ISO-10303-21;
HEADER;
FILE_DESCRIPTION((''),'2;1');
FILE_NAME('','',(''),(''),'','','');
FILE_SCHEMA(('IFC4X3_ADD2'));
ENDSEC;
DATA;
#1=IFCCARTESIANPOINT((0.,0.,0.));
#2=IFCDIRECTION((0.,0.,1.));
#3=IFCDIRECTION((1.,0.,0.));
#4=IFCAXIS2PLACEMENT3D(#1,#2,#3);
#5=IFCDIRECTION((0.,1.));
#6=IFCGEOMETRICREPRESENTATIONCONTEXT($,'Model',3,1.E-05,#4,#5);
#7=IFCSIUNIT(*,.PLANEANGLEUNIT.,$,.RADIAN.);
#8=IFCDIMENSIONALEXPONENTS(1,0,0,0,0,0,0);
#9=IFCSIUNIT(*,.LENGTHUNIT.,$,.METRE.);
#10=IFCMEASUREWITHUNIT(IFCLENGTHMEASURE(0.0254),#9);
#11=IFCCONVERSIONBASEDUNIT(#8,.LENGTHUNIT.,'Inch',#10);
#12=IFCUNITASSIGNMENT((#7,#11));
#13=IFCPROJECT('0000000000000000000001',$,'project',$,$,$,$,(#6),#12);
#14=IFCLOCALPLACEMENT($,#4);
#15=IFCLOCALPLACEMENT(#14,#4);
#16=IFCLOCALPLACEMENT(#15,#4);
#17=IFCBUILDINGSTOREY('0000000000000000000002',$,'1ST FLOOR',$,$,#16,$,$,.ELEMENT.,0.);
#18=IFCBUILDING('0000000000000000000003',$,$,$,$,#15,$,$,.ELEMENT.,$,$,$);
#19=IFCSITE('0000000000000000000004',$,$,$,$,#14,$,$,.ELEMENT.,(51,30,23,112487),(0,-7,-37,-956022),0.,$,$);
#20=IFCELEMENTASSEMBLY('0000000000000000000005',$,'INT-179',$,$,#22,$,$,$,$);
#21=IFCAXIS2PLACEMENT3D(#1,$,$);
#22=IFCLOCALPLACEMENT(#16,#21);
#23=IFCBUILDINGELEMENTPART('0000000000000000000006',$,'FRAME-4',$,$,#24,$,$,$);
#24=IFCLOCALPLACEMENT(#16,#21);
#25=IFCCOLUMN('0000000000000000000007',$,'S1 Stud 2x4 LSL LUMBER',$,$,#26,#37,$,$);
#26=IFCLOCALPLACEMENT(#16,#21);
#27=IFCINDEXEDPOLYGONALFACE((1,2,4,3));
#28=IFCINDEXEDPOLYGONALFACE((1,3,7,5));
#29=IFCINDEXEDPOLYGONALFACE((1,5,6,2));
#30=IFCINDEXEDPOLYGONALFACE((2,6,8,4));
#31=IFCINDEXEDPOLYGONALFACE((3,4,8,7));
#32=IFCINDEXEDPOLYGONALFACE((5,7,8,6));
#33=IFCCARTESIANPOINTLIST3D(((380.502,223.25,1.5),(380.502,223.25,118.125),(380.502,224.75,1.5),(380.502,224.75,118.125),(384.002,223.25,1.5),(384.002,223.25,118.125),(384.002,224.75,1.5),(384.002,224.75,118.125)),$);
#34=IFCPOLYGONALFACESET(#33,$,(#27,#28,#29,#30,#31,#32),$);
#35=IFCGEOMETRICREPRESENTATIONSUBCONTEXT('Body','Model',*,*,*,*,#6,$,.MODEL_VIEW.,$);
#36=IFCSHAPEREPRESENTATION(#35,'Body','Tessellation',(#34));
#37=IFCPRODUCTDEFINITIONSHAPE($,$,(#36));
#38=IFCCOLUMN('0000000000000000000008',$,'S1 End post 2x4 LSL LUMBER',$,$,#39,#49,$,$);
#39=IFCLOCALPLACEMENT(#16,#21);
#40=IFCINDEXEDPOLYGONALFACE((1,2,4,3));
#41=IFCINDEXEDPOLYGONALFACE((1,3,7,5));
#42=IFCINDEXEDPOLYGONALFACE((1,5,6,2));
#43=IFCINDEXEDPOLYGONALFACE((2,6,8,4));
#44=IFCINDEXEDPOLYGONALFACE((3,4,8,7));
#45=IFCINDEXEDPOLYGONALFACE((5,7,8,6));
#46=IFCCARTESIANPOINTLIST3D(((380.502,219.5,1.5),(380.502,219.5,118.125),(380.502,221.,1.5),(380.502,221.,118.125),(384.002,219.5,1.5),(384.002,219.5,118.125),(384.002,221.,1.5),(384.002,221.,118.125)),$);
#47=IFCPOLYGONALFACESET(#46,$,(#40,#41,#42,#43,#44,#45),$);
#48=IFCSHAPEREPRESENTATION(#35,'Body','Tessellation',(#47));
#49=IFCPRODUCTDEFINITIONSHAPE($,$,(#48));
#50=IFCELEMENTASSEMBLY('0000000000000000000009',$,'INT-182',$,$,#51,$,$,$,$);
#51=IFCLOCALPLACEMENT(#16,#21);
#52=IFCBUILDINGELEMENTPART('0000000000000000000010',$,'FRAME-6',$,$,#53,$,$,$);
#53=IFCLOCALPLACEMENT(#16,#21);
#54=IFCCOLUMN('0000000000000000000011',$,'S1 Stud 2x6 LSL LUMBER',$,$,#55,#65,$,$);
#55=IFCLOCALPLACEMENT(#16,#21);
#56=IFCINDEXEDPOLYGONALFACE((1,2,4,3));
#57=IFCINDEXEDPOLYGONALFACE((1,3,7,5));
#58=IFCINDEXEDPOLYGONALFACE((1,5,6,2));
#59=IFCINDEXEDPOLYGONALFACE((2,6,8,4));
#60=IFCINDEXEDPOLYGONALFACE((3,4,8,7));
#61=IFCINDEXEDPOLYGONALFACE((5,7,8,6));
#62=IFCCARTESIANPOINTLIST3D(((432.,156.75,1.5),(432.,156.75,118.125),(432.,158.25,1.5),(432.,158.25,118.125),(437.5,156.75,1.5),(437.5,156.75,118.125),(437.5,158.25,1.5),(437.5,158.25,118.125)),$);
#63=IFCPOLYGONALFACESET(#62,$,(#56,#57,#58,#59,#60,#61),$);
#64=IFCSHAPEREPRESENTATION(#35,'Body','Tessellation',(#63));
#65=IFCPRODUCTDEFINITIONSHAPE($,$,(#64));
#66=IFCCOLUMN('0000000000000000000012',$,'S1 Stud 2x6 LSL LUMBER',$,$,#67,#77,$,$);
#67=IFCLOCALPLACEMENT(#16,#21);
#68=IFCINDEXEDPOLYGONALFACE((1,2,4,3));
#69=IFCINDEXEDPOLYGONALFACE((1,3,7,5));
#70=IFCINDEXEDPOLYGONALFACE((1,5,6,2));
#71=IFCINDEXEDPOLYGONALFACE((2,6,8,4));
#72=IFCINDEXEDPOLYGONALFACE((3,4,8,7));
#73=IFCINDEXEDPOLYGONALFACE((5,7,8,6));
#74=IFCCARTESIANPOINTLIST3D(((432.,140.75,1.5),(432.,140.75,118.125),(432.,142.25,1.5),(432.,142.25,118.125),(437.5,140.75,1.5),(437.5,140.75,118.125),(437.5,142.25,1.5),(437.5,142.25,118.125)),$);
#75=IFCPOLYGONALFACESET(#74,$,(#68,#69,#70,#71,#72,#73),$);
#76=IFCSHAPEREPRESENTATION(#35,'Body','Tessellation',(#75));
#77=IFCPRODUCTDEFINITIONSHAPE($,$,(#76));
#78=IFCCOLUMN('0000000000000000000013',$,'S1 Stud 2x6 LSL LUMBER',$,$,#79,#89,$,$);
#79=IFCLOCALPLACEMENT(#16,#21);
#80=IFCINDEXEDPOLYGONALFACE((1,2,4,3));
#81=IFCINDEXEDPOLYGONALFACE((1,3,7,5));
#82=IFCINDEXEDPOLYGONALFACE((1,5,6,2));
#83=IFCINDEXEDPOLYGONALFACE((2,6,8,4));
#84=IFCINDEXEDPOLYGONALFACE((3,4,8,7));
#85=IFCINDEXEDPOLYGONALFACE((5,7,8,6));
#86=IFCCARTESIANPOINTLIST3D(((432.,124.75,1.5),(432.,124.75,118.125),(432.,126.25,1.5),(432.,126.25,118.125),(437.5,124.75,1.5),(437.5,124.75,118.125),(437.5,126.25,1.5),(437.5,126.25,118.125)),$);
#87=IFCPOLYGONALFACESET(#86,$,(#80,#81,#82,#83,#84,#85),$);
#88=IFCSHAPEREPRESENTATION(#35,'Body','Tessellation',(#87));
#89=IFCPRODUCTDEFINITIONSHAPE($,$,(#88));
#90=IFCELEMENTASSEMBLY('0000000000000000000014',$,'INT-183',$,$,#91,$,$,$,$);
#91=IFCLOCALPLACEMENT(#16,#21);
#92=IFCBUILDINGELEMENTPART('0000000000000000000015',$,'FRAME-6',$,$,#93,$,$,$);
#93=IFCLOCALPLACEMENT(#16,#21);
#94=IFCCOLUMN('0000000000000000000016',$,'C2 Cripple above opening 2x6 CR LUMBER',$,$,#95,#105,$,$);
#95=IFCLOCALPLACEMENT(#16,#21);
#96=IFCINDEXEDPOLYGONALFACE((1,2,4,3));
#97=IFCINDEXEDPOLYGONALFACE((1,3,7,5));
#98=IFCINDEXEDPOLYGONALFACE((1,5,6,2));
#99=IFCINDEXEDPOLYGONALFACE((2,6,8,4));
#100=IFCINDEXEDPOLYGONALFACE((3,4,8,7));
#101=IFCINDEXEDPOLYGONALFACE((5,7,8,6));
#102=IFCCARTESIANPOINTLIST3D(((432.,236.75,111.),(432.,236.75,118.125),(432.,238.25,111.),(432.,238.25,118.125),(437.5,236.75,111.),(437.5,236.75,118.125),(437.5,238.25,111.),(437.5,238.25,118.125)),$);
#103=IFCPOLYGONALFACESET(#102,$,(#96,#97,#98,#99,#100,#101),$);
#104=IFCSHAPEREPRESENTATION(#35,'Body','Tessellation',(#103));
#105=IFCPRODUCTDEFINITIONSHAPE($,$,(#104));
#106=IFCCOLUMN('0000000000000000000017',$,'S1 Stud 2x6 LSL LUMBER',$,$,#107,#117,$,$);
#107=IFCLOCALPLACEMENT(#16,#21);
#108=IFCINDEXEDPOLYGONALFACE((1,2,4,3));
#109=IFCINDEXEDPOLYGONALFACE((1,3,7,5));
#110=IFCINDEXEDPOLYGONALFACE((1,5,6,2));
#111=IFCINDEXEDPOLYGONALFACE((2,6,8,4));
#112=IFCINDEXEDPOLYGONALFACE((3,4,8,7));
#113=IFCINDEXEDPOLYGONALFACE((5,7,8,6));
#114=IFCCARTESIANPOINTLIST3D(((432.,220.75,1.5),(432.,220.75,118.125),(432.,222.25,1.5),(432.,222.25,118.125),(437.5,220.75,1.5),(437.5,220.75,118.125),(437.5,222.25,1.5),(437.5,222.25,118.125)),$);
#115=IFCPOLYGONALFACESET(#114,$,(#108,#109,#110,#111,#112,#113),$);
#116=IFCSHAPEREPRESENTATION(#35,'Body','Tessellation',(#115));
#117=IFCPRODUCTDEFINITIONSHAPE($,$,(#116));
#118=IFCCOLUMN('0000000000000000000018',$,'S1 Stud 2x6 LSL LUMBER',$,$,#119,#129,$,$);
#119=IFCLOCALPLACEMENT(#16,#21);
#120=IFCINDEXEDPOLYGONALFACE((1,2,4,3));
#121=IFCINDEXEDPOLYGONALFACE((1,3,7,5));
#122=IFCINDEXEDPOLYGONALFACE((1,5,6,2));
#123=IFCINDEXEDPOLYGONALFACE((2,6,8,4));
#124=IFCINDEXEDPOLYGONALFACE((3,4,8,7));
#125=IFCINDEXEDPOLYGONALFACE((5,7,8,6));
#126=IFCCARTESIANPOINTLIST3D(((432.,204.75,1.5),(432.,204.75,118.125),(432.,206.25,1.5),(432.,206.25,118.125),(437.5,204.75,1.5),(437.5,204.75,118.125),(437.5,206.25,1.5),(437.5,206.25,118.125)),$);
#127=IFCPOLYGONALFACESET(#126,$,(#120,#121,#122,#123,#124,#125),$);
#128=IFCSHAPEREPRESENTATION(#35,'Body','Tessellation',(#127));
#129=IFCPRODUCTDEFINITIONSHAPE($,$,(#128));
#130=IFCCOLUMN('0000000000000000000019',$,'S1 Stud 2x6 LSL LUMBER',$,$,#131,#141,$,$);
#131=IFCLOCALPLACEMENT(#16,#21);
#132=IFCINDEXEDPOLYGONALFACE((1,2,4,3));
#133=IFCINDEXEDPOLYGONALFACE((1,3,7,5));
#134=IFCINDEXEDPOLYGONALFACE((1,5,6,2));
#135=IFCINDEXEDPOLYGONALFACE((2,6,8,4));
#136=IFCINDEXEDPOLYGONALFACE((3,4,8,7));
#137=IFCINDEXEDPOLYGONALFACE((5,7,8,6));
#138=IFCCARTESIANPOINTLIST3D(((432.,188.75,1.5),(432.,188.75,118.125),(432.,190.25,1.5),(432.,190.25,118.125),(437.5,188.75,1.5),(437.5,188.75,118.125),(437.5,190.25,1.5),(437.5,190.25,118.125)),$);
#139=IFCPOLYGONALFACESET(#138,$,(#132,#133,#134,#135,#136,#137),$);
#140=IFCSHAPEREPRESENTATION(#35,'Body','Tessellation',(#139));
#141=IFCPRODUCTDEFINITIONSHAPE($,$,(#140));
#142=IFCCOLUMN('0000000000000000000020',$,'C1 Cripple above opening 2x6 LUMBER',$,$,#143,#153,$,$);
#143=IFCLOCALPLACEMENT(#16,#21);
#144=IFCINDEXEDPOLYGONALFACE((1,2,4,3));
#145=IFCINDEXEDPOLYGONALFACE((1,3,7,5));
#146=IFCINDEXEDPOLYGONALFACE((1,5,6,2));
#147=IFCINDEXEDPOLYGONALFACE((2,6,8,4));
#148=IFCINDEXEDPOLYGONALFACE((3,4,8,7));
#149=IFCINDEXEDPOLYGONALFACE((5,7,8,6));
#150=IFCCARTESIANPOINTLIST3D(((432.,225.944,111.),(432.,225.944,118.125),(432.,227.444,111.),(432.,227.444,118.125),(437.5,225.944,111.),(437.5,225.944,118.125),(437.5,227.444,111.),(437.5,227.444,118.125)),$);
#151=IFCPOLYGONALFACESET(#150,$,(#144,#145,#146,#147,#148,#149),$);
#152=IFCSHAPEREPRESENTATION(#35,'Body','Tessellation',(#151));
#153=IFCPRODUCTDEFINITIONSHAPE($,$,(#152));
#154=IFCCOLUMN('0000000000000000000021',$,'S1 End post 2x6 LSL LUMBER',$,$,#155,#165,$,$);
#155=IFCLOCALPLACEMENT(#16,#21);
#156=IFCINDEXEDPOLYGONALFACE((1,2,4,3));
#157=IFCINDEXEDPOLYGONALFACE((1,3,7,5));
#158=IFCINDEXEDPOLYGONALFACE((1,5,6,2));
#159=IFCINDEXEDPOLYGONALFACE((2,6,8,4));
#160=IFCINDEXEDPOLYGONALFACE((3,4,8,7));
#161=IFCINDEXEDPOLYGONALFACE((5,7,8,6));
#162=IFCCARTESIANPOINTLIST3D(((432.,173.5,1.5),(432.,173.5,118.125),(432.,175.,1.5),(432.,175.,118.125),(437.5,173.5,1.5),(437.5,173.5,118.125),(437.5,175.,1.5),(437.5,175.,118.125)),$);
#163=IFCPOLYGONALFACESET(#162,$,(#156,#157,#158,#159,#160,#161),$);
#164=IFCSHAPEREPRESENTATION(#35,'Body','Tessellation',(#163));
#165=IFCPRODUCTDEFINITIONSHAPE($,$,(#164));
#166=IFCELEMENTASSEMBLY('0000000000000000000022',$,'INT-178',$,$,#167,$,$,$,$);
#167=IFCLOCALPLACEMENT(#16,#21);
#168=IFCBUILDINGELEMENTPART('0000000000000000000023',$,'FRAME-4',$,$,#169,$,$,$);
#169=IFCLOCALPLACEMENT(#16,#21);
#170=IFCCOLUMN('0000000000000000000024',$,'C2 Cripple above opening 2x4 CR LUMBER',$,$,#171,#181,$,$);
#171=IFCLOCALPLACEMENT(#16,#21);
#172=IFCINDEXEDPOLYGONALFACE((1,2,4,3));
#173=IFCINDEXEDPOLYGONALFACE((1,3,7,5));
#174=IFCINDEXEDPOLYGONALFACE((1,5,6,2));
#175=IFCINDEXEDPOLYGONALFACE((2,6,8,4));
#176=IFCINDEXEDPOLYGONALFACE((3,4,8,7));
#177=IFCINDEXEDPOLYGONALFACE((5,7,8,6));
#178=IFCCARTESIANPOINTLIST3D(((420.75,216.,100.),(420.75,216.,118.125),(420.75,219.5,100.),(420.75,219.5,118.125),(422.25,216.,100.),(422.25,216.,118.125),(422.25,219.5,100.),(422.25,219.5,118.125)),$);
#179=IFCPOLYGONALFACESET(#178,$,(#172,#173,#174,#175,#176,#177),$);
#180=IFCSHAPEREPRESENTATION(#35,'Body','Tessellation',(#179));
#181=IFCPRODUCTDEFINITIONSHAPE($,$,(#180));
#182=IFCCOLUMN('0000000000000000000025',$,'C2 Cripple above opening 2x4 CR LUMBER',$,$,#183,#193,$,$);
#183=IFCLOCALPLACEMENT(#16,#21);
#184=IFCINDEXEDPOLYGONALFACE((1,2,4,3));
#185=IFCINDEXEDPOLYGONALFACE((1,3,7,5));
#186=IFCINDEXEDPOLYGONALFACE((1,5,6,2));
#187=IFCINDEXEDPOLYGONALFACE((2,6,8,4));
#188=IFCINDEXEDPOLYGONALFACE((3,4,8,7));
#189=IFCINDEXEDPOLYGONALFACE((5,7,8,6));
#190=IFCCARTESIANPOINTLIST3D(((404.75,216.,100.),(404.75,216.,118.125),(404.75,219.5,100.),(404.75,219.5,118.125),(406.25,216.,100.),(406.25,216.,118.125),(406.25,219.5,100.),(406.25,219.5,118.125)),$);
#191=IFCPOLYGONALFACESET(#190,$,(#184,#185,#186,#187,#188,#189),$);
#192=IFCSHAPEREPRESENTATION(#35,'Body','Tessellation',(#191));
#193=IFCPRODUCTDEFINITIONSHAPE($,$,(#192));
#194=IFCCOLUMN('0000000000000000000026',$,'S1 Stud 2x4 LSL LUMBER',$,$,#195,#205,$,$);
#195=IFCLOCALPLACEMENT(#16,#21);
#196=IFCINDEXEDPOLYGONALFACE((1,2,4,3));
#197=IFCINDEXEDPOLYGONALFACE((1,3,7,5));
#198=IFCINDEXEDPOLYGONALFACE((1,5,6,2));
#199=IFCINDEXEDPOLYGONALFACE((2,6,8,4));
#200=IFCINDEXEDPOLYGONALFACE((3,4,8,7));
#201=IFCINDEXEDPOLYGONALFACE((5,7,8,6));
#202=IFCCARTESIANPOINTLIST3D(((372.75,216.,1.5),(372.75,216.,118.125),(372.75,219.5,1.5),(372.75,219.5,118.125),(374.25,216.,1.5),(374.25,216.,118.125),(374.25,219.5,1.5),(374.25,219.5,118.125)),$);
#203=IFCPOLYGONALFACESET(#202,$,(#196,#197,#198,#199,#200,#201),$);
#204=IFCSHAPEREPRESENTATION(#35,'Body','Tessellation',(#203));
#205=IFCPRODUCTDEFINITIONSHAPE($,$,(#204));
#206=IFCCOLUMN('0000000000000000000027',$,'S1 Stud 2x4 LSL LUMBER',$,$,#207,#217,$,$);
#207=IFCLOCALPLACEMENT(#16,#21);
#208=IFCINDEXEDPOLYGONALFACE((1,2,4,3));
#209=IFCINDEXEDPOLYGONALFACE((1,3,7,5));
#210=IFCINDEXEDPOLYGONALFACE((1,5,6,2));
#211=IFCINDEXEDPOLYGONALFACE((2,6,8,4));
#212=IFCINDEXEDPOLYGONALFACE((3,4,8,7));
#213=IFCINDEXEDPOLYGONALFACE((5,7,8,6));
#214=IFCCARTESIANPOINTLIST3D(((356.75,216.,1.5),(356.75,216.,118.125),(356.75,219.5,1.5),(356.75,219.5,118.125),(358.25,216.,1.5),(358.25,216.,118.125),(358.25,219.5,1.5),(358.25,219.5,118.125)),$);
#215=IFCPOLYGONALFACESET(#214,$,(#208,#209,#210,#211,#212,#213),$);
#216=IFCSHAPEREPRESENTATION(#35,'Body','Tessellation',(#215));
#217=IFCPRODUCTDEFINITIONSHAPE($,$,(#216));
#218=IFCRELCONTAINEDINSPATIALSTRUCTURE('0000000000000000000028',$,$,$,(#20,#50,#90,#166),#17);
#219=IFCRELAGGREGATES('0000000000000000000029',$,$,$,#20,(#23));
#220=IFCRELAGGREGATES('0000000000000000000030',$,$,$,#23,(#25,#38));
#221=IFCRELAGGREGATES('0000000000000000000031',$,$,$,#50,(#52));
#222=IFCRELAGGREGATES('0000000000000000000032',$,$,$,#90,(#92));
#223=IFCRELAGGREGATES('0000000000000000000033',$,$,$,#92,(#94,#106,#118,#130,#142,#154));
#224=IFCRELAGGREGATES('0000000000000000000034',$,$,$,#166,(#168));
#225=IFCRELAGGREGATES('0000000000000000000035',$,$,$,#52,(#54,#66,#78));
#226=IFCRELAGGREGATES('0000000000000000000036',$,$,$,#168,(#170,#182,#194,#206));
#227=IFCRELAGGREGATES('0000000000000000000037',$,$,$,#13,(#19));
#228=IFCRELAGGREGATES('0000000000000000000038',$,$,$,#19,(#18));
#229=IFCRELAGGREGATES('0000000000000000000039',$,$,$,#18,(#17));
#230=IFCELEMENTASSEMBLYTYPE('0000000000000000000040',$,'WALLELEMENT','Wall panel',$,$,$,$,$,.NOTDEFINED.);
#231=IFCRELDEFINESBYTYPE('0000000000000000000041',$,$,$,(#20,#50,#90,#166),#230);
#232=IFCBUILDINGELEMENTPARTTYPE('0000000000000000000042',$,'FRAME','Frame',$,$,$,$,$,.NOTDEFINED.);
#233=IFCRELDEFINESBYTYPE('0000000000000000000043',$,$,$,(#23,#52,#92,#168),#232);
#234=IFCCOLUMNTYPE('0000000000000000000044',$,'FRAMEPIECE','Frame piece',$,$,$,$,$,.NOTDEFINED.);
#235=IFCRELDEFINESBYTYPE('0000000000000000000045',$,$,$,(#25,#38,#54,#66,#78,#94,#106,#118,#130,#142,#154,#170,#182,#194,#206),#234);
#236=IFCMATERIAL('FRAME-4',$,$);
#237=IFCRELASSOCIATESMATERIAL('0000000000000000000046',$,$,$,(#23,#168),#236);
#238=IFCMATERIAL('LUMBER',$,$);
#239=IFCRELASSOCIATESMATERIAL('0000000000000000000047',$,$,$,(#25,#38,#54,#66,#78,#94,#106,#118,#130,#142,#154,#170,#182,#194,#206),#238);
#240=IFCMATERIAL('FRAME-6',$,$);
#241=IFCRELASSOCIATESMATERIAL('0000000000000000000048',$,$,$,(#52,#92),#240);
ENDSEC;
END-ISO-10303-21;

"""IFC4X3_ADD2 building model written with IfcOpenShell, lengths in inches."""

from ifc_helpers import new_model, entity, si_unit, converted_unit, direction, frame, origin_with_axes, origin_2d_with_axis, place, context, subcontext, project, spatial, rectangle, extrude, material, type_object, element, aggregate, save


model = new_model("IFC4X3_ADD2")

# Units and contexts
model_context = context("Model", 3, precision=1e-05, world=origin_with_axes(), true_north=direction((0.0, 1.0)))
body_context = subcontext(model_context, "Body", "Model", "MODEL_VIEW")
ifc_project = project(units=[si_unit("PLANEANGLEUNIT", "RADIAN"), converted_unit("LENGTHUNIT", "Inch", entity("IfcLengthMeasure", 0.0254), si_unit("LENGTHUNIT", "METRE"), dimensions=[1, 0, 0, 0, 0, 0, 0])], contexts=[model_context])

# Site, building, storey
site_placement = place(None, origin_with_axes())
site = spatial("IfcSite", under=ifc_project, at=site_placement, CompositionType="ELEMENT", RefLatitude=(51, 30, 23, 112487), RefLongitude=(0, -7, -37, -956022), RefElevation=0.0)
building_placement = place(site_placement, origin_with_axes())
building = spatial("IfcBuilding", under=site, at=building_placement, CompositionType="ELEMENT")
storey_placement = place(building_placement, origin_with_axes())
storey = spatial("IfcBuildingStorey", under=building, at=storey_placement, Name="1ST FLOOR", CompositionType="ELEMENT", Elevation=0.0)

# Element assemblies, building element parts, columns
element_assembly_type = type_object("IfcElementAssemblyType", Name="WALLELEMENT", Description="Wall panel", PredefinedType="NOTDEFINED")
assembly_1_placement = place(storey_placement, origin_with_axes())
assembly_1 = element("IfcElementAssembly", 1, at=assembly_1_placement, inside=storey, type_object=element_assembly_type, Name="INT-179")
ifc_material_1 = material(Name="FRAME-4")
building_element_part_type = type_object("IfcBuildingElementPartType", Name="FRAME", Description="Frame", PredefinedType="NOTDEFINED")
building_element_part_1_placement = place(storey_placement, origin_with_axes())
building_element_part_1 = element("IfcBuildingElementPart", 2, at=building_element_part_1_placement, type_object=building_element_part_type, material=ifc_material_1, Name="FRAME-4")
aggregate(assembly_1, [building_element_part_1])
ifc_material_2 = material(Name="LUMBER")
column_type = type_object("IfcColumnType", Name="FRAMEPIECE", Description="Frame piece", PredefinedType="NOTDEFINED")
column_1_placement = place(storey_placement, frame((382.252, 224.0, 118.125), z_axis=(0.0, 0.0, -1.0), x_axis=(0.0, 1.0, 0.0)))
column_1 = element("IfcColumn", 3, at=column_1_placement, type_object=column_type, material=ifc_material_2, Name="S1 Stud 2x4 LSL LUMBER", context=body_context, shape_type="SweptSolid", body=[
    extrude(rectangle(XDim=1.5, YDim=3.5, at=origin_2d_with_axis()), origin_with_axes(), (0.0, 0.0, 1.0), 116.625),
])
column_2_placement = place(storey_placement, frame((382.252, 220.25, 118.125), z_axis=(0.0, 0.0, -1.0), x_axis=(0.0, 1.0, 0.0)))
column_2 = element("IfcColumn", 4, at=column_2_placement, type_object=column_type, material=ifc_material_2, Name="S1 End post 2x4 LSL LUMBER", context=body_context, shape_type="SweptSolid", body=[
    extrude(rectangle(XDim=1.5, YDim=3.5, at=origin_2d_with_axis()), origin_with_axes(), (0.0, 0.0, 1.0), 116.625),
])
aggregate(building_element_part_1, [column_1, column_2])
assembly_2_placement = place(storey_placement, origin_with_axes())
assembly_2 = element("IfcElementAssembly", 5, at=assembly_2_placement, inside=storey, type_object=element_assembly_type, Name="INT-182")
ifc_material_3 = material(Name="FRAME-6")
building_element_part_2_placement = place(storey_placement, origin_with_axes())
building_element_part_2 = element("IfcBuildingElementPart", 6, at=building_element_part_2_placement, type_object=building_element_part_type, material=ifc_material_3, Name="FRAME-6")
aggregate(assembly_2, [building_element_part_2])
column_3_placement = place(storey_placement, frame((434.75, 157.5, 118.125), z_axis=(0.0, 0.0, -1.0), x_axis=(0.0, 1.0, 0.0)))
column_3 = element("IfcColumn", 7, at=column_3_placement, type_object=column_type, material=ifc_material_2, Name="S1 Stud 2x6 LSL LUMBER", context=body_context, shape_type="SweptSolid", body=[
    extrude(rectangle(XDim=1.5, YDim=5.5, at=origin_2d_with_axis()), origin_with_axes(), (0.0, 0.0, 1.0), 116.625),
])
column_4_placement = place(storey_placement, frame((434.75, 141.5, 118.125), z_axis=(0.0, 0.0, -1.0), x_axis=(0.0, 1.0, 0.0)))
column_4 = element("IfcColumn", 8, at=column_4_placement, type_object=column_type, material=ifc_material_2, Name="S1 Stud 2x6 LSL LUMBER", context=body_context, shape_type="SweptSolid", body=[
    extrude(rectangle(XDim=1.5, YDim=5.5, at=origin_2d_with_axis()), origin_with_axes(), (0.0, 0.0, 1.0), 116.625),
])
column_5_placement = place(storey_placement, frame((434.75, 125.5, 118.125), z_axis=(0.0, 0.0, -1.0), x_axis=(0.0, 1.0, 0.0)))
column_5 = element("IfcColumn", 9, at=column_5_placement, type_object=column_type, material=ifc_material_2, Name="S1 Stud 2x6 LSL LUMBER", context=body_context, shape_type="SweptSolid", body=[
    extrude(rectangle(XDim=1.5, YDim=5.5, at=origin_2d_with_axis()), origin_with_axes(), (0.0, 0.0, 1.0), 116.625),
])
assembly_3_placement = place(storey_placement, origin_with_axes())
assembly_3 = element("IfcElementAssembly", 10, at=assembly_3_placement, inside=storey, type_object=element_assembly_type, Name="INT-183")
building_element_part_3_placement = place(storey_placement, origin_with_axes())
building_element_part_3 = element("IfcBuildingElementPart", 11, at=building_element_part_3_placement, type_object=building_element_part_type, material=ifc_material_3, Name="FRAME-6")
aggregate(assembly_3, [building_element_part_3])
column_6_placement = place(storey_placement, frame((434.75, 237.5, 118.125), z_axis=(0.0, 0.0, -1.0), x_axis=(0.0, 1.0, 0.0)))
column_6 = element("IfcColumn", 12, at=column_6_placement, type_object=column_type, material=ifc_material_2, Name="C2 Cripple above opening 2x6 CR LUMBER", context=body_context, shape_type="SweptSolid", body=[
    extrude(rectangle(XDim=1.5, YDim=5.5, at=origin_2d_with_axis()), origin_with_axes(), (0.0, 0.0, 1.0), 7.125),
])
column_7_placement = place(storey_placement, frame((434.75, 221.5, 118.125), z_axis=(0.0, 0.0, -1.0), x_axis=(0.0, 1.0, 0.0)))
column_7 = element("IfcColumn", 13, at=column_7_placement, type_object=column_type, material=ifc_material_2, Name="S1 Stud 2x6 LSL LUMBER", context=body_context, shape_type="SweptSolid", body=[
    extrude(rectangle(XDim=1.5, YDim=5.5, at=origin_2d_with_axis()), origin_with_axes(), (0.0, 0.0, 1.0), 116.625),
])
column_8_placement = place(storey_placement, frame((434.75, 205.5, 118.125), z_axis=(0.0, 0.0, -1.0), x_axis=(0.0, 1.0, 0.0)))
column_8 = element("IfcColumn", 14, at=column_8_placement, type_object=column_type, material=ifc_material_2, Name="S1 Stud 2x6 LSL LUMBER", context=body_context, shape_type="SweptSolid", body=[
    extrude(rectangle(XDim=1.5, YDim=5.5, at=origin_2d_with_axis()), origin_with_axes(), (0.0, 0.0, 1.0), 116.625),
])
column_9_placement = place(storey_placement, frame((434.75, 189.5, 118.125), z_axis=(0.0, 0.0, -1.0), x_axis=(0.0, 1.0, 0.0)))
column_9 = element("IfcColumn", 15, at=column_9_placement, type_object=column_type, material=ifc_material_2, Name="S1 Stud 2x6 LSL LUMBER", context=body_context, shape_type="SweptSolid", body=[
    extrude(rectangle(XDim=1.5, YDim=5.5, at=origin_2d_with_axis()), origin_with_axes(), (0.0, 0.0, 1.0), 116.625),
])
column_10_placement = place(storey_placement, frame((434.75, 226.694, 118.125), z_axis=(0.0, 0.0, -1.0), x_axis=(0.0, 1.0, 0.0)))
column_10 = element("IfcColumn", 16, at=column_10_placement, type_object=column_type, material=ifc_material_2, Name="C1 Cripple above opening 2x6 LUMBER", context=body_context, shape_type="SweptSolid", body=[
    extrude(rectangle(XDim=1.5, YDim=5.5, at=origin_2d_with_axis()), origin_with_axes(), (0.0, 0.0, 1.0), 7.125),
])
column_11_placement = place(storey_placement, frame((434.75, 174.25, 118.125), z_axis=(0.0, 0.0, -1.0), x_axis=(0.0, 1.0, 0.0)))
column_11 = element("IfcColumn", 17, at=column_11_placement, type_object=column_type, material=ifc_material_2, Name="S1 End post 2x6 LSL LUMBER", context=body_context, shape_type="SweptSolid", body=[
    extrude(rectangle(XDim=1.5, YDim=5.5, at=origin_2d_with_axis()), origin_with_axes(), (0.0, 0.0, 1.0), 116.625),
])
aggregate(building_element_part_3, [column_6, column_7, column_8, column_9, column_10, column_11])
assembly_4_placement = place(storey_placement, origin_with_axes())
assembly_4 = element("IfcElementAssembly", 18, at=assembly_4_placement, inside=storey, type_object=element_assembly_type, Name="INT-178")
building_element_part_4_placement = place(storey_placement, origin_with_axes())
building_element_part_4 = element("IfcBuildingElementPart", 19, at=building_element_part_4_placement, type_object=building_element_part_type, material=ifc_material_1, Name="FRAME-4")
aggregate(assembly_4, [building_element_part_4])
column_12_placement = place(storey_placement, frame((421.5, 217.75, 118.125), z_axis=(0.0, 0.0, -1.0), x_axis=(1.0, 0.0, 0.0)))
column_12 = element("IfcColumn", 20, at=column_12_placement, type_object=column_type, material=ifc_material_2, Name="C2 Cripple above opening 2x4 CR LUMBER", context=body_context, shape_type="SweptSolid", body=[
    extrude(rectangle(XDim=1.5, YDim=3.5, at=origin_2d_with_axis()), origin_with_axes(), (0.0, 0.0, 1.0), 18.125),
])
column_13_placement = place(storey_placement, frame((405.5, 217.75, 118.125), z_axis=(0.0, 0.0, -1.0), x_axis=(1.0, 0.0, 0.0)))
column_13 = element("IfcColumn", 21, at=column_13_placement, type_object=column_type, material=ifc_material_2, Name="C2 Cripple above opening 2x4 CR LUMBER", context=body_context, shape_type="SweptSolid", body=[
    extrude(rectangle(XDim=1.5, YDim=3.5, at=origin_2d_with_axis()), origin_with_axes(), (0.0, 0.0, 1.0), 18.125),
])
column_14_placement = place(storey_placement, frame((373.5, 217.75, 118.125), z_axis=(0.0, 0.0, -1.0), x_axis=(1.0, 0.0, 0.0)))
column_14 = element("IfcColumn", 22, at=column_14_placement, type_object=column_type, material=ifc_material_2, Name="S1 Stud 2x4 LSL LUMBER", context=body_context, shape_type="SweptSolid", body=[
    extrude(rectangle(XDim=1.5, YDim=3.5, at=origin_2d_with_axis()), origin_with_axes(), (0.0, 0.0, 1.0), 116.625),
])
column_15_placement = place(storey_placement, frame((357.5, 217.75, 118.125), z_axis=(0.0, 0.0, -1.0), x_axis=(1.0, 0.0, 0.0)))
column_15 = element("IfcColumn", 23, at=column_15_placement, type_object=column_type, material=ifc_material_2, Name="S1 Stud 2x4 LSL LUMBER", context=body_context, shape_type="SweptSolid", body=[
    extrude(rectangle(XDim=1.5, YDim=3.5, at=origin_2d_with_axis()), origin_with_axes(), (0.0, 0.0, 1.0), 116.625),
])

aggregate(building_element_part_2, [column_3, column_4, column_5])
aggregate(building_element_part_4, [column_12, column_13, column_14, column_15])

save(model, "model.ifc")
